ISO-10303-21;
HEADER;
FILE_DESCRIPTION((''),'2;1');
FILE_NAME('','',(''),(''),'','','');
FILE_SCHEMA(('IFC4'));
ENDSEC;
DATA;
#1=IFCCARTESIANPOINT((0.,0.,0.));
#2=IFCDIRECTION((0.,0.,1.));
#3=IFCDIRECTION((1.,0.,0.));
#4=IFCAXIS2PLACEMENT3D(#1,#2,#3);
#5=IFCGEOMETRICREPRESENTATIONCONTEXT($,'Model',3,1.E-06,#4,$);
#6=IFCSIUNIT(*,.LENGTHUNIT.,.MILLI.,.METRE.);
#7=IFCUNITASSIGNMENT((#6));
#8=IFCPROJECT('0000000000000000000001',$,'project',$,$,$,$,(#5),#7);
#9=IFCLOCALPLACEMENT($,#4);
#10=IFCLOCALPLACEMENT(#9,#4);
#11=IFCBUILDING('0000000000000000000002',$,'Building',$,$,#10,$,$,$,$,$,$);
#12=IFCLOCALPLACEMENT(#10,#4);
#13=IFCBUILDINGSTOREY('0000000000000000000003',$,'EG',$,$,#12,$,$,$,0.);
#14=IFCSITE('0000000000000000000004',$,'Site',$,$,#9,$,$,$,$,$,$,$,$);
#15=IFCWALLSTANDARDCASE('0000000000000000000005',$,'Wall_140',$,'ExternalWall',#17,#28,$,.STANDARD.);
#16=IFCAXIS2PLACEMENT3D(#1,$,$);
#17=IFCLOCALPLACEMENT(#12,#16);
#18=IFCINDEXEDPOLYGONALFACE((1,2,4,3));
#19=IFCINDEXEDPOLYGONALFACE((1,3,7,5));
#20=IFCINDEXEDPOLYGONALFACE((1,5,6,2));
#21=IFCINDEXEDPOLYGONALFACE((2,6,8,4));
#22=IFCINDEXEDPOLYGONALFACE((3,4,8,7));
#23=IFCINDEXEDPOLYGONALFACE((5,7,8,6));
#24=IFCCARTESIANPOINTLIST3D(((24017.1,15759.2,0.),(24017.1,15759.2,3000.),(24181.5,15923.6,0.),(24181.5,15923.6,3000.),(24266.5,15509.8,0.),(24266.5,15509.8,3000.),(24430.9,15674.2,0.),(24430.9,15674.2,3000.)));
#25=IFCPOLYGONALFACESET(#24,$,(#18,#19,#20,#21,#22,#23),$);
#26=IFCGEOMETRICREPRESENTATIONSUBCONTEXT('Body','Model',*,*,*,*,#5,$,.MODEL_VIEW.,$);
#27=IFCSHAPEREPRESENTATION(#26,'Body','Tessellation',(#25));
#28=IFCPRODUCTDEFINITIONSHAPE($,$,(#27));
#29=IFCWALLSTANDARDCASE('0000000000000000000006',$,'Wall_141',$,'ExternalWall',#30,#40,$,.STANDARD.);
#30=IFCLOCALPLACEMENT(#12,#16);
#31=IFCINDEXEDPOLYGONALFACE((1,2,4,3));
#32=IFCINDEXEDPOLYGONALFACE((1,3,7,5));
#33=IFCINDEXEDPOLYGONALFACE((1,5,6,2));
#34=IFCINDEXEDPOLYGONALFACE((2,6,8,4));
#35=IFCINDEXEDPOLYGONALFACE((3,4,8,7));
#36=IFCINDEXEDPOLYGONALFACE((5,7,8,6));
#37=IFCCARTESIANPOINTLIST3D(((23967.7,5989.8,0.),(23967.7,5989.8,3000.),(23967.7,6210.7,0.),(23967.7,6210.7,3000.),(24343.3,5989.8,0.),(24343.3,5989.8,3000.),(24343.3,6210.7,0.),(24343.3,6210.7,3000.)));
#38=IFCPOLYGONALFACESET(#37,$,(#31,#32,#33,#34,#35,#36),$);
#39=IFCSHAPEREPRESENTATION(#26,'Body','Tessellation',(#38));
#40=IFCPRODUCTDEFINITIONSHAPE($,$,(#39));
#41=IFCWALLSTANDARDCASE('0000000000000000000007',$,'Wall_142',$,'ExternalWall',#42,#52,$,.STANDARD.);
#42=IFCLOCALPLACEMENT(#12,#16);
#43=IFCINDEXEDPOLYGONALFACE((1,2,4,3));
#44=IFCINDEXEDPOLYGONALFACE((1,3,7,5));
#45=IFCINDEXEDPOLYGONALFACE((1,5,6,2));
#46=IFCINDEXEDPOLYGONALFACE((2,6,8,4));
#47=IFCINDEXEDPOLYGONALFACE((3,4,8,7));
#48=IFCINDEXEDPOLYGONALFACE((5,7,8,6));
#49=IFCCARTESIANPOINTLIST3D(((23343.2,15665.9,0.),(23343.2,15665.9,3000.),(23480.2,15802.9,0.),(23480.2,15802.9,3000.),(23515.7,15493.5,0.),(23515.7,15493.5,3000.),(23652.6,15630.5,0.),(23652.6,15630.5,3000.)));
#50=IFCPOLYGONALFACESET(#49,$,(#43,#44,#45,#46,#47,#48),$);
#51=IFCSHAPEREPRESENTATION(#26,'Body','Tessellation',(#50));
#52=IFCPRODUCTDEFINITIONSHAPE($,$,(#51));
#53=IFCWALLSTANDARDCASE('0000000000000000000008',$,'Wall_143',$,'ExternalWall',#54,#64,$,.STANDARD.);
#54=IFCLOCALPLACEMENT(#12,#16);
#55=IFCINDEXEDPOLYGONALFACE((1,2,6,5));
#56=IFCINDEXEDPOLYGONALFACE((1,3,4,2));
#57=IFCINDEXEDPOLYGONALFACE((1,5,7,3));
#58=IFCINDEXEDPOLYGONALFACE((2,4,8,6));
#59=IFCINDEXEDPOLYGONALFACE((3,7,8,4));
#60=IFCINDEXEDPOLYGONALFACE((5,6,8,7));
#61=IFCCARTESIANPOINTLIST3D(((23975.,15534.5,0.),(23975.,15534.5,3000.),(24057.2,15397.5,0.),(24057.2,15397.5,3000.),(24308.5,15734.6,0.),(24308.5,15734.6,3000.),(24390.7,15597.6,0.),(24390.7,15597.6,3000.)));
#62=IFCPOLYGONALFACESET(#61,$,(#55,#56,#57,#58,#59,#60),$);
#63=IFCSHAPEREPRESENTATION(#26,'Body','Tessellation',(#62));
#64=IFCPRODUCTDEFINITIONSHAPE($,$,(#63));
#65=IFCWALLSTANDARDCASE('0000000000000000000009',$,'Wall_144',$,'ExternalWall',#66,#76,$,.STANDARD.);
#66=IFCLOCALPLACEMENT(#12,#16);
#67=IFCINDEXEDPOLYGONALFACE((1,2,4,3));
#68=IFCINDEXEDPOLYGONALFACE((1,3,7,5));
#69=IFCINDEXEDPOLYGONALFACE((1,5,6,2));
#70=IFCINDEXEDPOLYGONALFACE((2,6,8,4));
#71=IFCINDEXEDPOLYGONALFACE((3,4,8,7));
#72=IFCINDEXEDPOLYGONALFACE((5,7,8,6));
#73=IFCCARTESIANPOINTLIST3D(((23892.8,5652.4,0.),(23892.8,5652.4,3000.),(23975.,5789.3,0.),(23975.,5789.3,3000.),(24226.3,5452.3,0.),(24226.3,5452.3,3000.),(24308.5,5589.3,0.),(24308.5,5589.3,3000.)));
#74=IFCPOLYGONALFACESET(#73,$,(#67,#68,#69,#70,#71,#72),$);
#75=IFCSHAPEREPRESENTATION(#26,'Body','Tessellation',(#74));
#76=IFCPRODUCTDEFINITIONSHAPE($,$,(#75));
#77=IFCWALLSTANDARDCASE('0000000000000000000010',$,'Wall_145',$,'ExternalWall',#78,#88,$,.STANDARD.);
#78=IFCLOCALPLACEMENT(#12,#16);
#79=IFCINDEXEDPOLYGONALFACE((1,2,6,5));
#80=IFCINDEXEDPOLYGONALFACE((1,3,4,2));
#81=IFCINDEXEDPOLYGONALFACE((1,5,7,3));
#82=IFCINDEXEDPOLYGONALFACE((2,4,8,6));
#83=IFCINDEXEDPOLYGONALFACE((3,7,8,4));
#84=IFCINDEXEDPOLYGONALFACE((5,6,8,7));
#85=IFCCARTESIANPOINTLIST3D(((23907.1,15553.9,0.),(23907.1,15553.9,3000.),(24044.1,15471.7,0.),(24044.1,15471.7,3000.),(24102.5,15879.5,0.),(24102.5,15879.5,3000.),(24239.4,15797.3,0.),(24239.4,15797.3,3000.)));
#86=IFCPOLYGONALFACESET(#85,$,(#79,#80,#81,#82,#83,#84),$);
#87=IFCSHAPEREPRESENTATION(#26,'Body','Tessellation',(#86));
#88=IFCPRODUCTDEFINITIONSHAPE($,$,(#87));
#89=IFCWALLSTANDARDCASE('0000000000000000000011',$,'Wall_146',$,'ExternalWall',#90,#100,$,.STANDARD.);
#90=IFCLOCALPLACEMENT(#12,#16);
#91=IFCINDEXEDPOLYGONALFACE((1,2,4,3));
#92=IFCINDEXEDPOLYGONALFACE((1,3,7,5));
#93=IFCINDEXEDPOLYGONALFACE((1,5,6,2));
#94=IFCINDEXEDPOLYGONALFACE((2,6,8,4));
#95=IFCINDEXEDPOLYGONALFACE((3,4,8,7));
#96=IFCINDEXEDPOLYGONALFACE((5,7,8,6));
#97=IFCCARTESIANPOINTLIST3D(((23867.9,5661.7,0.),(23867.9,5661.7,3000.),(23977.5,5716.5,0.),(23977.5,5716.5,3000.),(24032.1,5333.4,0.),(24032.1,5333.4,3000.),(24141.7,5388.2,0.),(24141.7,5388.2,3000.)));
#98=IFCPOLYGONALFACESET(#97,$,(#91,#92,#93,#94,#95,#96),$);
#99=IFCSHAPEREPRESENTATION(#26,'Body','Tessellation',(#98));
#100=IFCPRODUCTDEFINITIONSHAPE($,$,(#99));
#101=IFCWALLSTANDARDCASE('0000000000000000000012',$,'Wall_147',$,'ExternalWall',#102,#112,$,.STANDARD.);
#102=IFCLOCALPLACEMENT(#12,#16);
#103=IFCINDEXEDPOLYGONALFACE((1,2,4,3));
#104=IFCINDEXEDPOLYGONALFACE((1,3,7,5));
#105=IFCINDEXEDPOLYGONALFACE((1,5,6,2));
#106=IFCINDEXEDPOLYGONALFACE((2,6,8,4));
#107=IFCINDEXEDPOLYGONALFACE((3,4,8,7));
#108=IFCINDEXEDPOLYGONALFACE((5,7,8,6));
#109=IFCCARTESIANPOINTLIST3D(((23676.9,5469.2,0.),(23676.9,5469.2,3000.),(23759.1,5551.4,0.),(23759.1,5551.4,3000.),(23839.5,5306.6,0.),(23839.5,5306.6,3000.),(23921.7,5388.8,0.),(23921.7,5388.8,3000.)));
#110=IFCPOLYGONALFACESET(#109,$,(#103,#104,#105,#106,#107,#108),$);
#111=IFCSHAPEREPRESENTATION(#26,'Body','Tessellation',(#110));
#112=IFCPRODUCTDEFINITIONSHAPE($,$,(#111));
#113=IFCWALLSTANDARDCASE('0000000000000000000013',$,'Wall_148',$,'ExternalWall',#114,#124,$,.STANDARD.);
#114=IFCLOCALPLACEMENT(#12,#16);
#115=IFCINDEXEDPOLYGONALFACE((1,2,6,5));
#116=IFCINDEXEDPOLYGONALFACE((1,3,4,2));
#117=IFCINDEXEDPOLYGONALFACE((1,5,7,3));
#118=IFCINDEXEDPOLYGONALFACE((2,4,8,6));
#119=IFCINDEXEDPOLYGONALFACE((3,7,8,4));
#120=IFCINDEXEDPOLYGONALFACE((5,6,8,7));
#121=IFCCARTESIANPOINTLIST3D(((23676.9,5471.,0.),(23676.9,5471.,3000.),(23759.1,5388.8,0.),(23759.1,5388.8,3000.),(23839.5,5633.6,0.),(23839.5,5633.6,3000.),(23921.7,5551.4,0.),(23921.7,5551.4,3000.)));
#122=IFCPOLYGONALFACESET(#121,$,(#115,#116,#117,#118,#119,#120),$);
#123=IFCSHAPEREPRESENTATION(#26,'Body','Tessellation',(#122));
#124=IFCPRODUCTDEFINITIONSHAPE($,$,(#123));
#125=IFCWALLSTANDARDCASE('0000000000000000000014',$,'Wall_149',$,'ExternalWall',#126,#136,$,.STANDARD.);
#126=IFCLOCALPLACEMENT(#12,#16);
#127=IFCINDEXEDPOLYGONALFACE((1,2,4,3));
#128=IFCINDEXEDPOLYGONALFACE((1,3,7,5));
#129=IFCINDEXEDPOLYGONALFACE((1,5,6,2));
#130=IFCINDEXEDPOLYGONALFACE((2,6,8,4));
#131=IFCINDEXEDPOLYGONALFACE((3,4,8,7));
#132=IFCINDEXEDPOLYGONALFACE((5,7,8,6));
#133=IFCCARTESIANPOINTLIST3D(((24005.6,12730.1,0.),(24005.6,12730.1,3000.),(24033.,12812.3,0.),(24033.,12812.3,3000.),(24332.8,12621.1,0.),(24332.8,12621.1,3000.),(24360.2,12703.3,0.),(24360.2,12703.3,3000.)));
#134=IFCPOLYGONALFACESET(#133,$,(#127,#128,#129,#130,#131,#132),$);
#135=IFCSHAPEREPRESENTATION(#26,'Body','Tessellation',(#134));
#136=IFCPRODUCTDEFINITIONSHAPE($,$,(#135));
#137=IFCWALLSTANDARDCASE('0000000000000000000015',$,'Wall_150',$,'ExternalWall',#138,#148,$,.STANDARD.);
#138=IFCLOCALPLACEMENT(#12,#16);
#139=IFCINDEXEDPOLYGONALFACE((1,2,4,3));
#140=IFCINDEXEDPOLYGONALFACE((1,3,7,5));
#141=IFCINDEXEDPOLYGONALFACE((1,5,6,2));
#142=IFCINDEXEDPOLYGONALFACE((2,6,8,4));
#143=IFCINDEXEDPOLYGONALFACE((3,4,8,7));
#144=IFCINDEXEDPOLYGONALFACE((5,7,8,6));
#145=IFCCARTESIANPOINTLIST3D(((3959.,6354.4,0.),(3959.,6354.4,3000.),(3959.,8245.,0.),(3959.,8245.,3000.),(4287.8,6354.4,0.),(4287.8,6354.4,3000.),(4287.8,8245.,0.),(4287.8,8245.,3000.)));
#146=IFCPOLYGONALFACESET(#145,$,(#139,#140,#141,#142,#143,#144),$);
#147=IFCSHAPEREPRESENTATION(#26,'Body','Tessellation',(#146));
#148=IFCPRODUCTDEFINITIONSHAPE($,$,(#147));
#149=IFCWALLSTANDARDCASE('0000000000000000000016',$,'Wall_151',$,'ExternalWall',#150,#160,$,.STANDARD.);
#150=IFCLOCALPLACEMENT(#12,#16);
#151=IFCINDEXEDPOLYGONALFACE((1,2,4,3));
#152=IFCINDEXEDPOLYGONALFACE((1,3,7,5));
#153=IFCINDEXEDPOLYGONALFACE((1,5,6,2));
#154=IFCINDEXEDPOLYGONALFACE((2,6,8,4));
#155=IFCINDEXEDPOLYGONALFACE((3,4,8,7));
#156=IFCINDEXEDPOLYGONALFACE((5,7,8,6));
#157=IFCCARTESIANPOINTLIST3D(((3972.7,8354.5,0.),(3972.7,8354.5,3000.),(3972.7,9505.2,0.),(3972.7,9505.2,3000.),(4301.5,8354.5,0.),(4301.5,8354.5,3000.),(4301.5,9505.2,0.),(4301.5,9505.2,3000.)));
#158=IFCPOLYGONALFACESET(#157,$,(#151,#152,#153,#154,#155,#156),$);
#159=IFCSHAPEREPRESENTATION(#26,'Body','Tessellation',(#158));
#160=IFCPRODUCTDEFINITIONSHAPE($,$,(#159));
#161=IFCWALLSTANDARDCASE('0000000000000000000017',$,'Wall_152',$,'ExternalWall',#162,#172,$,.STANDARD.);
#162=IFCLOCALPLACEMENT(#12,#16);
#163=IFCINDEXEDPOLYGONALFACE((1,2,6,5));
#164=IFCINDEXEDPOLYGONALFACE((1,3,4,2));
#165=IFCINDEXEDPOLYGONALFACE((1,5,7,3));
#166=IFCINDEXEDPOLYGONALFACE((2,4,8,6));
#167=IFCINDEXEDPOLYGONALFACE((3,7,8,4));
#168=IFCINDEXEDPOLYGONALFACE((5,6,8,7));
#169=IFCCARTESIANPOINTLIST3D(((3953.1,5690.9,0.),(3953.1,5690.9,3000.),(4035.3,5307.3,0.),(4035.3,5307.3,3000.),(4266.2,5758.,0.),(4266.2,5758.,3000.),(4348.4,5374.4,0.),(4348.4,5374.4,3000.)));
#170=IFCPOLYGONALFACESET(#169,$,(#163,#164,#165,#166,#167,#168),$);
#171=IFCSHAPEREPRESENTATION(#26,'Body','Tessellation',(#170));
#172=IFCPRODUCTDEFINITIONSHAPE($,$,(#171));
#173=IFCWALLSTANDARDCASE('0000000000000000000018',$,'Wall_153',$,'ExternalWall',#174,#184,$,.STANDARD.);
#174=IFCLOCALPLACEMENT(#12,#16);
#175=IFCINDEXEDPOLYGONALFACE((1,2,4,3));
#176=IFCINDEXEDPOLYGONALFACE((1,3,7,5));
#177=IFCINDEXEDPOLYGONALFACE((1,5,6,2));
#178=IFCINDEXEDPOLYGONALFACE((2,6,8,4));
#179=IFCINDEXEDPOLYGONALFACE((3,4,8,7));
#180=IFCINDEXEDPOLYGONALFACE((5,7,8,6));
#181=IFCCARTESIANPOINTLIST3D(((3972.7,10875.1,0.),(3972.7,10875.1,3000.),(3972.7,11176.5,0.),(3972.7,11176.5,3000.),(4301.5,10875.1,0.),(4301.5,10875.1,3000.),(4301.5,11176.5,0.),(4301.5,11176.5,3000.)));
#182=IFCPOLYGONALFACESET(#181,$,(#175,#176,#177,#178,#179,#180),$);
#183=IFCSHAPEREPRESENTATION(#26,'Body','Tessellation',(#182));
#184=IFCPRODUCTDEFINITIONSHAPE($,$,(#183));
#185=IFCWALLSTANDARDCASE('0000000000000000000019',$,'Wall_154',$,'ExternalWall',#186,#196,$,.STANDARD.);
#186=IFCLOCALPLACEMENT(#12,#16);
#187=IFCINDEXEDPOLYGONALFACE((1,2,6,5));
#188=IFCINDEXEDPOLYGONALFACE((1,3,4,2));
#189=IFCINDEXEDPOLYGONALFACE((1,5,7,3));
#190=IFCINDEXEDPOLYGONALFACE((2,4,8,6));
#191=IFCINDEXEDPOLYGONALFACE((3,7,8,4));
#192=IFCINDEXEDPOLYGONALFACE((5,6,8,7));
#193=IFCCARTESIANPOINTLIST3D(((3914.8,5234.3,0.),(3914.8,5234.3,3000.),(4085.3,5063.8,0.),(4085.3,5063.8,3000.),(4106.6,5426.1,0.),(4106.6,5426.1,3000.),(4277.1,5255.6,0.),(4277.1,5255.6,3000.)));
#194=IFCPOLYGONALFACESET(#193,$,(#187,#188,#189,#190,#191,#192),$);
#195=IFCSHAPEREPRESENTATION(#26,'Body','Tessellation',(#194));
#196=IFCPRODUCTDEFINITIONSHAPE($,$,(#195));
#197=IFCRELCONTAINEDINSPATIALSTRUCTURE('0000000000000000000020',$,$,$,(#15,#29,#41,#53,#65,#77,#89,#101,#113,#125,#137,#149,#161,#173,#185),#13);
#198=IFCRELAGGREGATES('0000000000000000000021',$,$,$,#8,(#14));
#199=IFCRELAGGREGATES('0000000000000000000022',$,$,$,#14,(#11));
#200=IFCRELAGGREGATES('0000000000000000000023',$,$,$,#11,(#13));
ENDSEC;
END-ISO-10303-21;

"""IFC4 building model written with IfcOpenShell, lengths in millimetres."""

from ifc_helpers import new_model, si_unit, frame, origin_with_axes, place, context, subcontext, project, spatial, rectangle, extrude, element, save


model = new_model("IFC4")

# Units and contexts
model_context = context("Model", 3, precision=1e-06, world=origin_with_axes())
body_context = subcontext(model_context, "Body", "Model", "MODEL_VIEW")
ifc_project = project(units=[si_unit("LENGTHUNIT", "METRE", prefix="MILLI")], contexts=[model_context])

# Site, building, storey
site_placement = place(None, origin_with_axes())
site = spatial("IfcSite", under=ifc_project, at=site_placement, Name="Site")
building_placement = place(site_placement, origin_with_axes())
building = spatial("IfcBuilding", under=site, at=building_placement, Name="Building")
storey_placement = place(building_placement, origin_with_axes())
storey = spatial("IfcBuildingStorey", under=building, at=storey_placement, Name="EG", Elevation=0.0)

# Walls
wall_1_placement = place(storey_placement, origin_with_axes())
element("IfcWallStandardCase", 1, at=wall_1_placement, inside=storey, Name="Wall_140", ObjectType="ExternalWall", PredefinedType="STANDARD", context=body_context, shape_type="SweptSolid", body=[
    extrude(rectangle(XDim=232.5, YDim=352.7), frame((24224.0, 15716.7, 0.0), z_axis=(0.0, 0.0, 1.0), x_axis=(0.707107, 0.707107, 0.0)), (0.0, 0.0, 1.0), 3000.0),
])
wall_2_placement = place(storey_placement, origin_with_axes())
element("IfcWallStandardCase", 2, at=wall_2_placement, inside=storey, Name="Wall_141", ObjectType="ExternalWall", PredefinedType="STANDARD", context=body_context, shape_type="SweptSolid", body=[
    extrude(rectangle(XDim=220.9, YDim=375.6), frame((24155.5, 6100.3, 0.0), z_axis=(0.0, 0.0, 1.0), x_axis=(0.0, -1.0, 0.0)), (0.0, 0.0, 1.0), 3000.0),
])
wall_3_placement = place(storey_placement, origin_with_axes())
element("IfcWallStandardCase", 3, at=wall_3_placement, inside=storey, Name="Wall_142", ObjectType="ExternalWall", PredefinedType="STANDARD", context=body_context, shape_type="SweptSolid", body=[
    extrude(rectangle(XDim=193.7, YDim=243.8), frame((23497.9, 15648.2, 0.0), z_axis=(0.0, 0.0, 1.0), x_axis=(-0.707107, -0.707107, 0.0)), (0.0, 0.0, 1.0), 3000.0),
])
wall_4_placement = place(storey_placement, origin_with_axes())
element("IfcWallStandardCase", 4, at=wall_4_placement, inside=storey, Name="Wall_143", ObjectType="ExternalWall", PredefinedType="STANDARD", context=body_context, shape_type="SweptSolid", body=[
    extrude(rectangle(XDim=159.8, YDim=388.9), frame((24182.9, 15566.0, 0.0), z_axis=(0.0, 0.0, 1.0), x_axis=(-0.514496, 0.857493, 0.0)), (0.0, 0.0, 1.0), 3000.0),
])
wall_5_placement = place(storey_placement, origin_with_axes())
element("IfcWallStandardCase", 5, at=wall_5_placement, inside=storey, Name="Wall_144", ObjectType="ExternalWall", PredefinedType="STANDARD", context=body_context, shape_type="SweptSolid", body=[
    extrude(rectangle(XDim=159.8, YDim=388.9), frame((24100.7, 5620.8, 0.0), z_axis=(0.0, 0.0, 1.0), x_axis=(-0.514496, -0.857493, 0.0)), (0.0, 0.0, 1.0), 3000.0),
])
wall_6_placement = place(storey_placement, origin_with_axes())
element("IfcWallStandardCase", 6, at=wall_6_placement, inside=storey, Name="Wall_145", ObjectType="ExternalWall", PredefinedType="STANDARD", context=body_context, shape_type="SweptSolid", body=[
    extrude(rectangle(XDim=159.8, YDim=379.6), frame((24073.3, 15675.6, 0.0), z_axis=(0.0, 0.0, 1.0), x_axis=(-0.857493, 0.514496, 0.0)), (0.0, 0.0, 1.0), 3000.0),
])
wall_7_placement = place(storey_placement, origin_with_axes())
element("IfcWallStandardCase", 7, at=wall_7_placement, inside=storey, Name="Wall_146", ObjectType="ExternalWall", PredefinedType="STANDARD", context=body_context, shape_type="SweptSolid", body=[
    extrude(rectangle(XDim=122.5, YDim=367.0), frame((24004.8, 5524.9, 0.0), z_axis=(0.0, 0.0, 1.0), x_axis=(-0.894427, -0.447214, 0.0)), (0.0, 0.0, 1.0), 3000.0),
])
wall_8_placement = place(storey_placement, origin_with_axes())
element("IfcWallStandardCase", 8, at=wall_8_placement, inside=storey, Name="Wall_147", ObjectType="ExternalWall", PredefinedType="STANDARD", context=body_context, shape_type="SweptSolid", body=[
    extrude(rectangle(XDim=116.2, YDim=230.0), frame((23799.3, 5429.0, 0.0), z_axis=(0.0, 0.0, 1.0), x_axis=(-0.707107, -0.707107, 0.0)), (0.0, 0.0, 1.0), 3000.0),
])
wall_9_placement = place(storey_placement, origin_with_axes())
element("IfcWallStandardCase", 9, at=wall_9_placement, inside=storey, Name="Wall_148", ObjectType="ExternalWall", PredefinedType="STANDARD", context=body_context, shape_type="SweptSolid", body=[
    extrude(rectangle(XDim=116.2, YDim=230.0), frame((23799.3, 5511.2, 0.0), z_axis=(0.0, 0.0, 1.0), x_axis=(-0.707107, 0.707107, 0.0)), (0.0, 0.0, 1.0), 3000.0),
])
wall_10_placement = place(storey_placement, origin_with_axes())
element("IfcWallStandardCase", 10, at=wall_10_placement, inside=storey, Name="Wall_149", ObjectType="ExternalWall", PredefinedType="STANDARD", context=body_context, shape_type="SweptSolid", body=[
    extrude(rectangle(XDim=86.6, YDim=345.0), frame((24182.9, 12716.7, 0.0), z_axis=(0.0, 0.0, 1.0), x_axis=(0.316228, 0.948683, 0.0)), (0.0, 0.0, 1.0), 3000.0),
])
wall_11_placement = place(storey_placement, origin_with_axes())
element("IfcWallStandardCase", 11, at=wall_11_placement, inside=storey, Name="Wall_150", ObjectType="ExternalWall", PredefinedType="STANDARD", context=body_context, shape_type="SweptSolid", body=[
    extrude(rectangle(XDim=1890.6, YDim=328.8), frame((4123.4, 7299.7, 0.0), z_axis=(0.0, 0.0, 1.0), x_axis=(0.0, 1.0, 0.0)), (0.0, 0.0, 1.0), 3000.0),
])
wall_12_placement = place(storey_placement, origin_with_axes())
element("IfcWallStandardCase", 12, at=wall_12_placement, inside=storey, Name="Wall_151", ObjectType="ExternalWall", PredefinedType="STANDARD", context=body_context, shape_type="SweptSolid", body=[
    extrude(rectangle(XDim=1150.7, YDim=328.8), frame((4137.1, 8929.9, 0.0), z_axis=(0.0, 0.0, 1.0), x_axis=(0.0, 1.0, 0.0)), (0.0, 0.0, 1.0), 3000.0),
])
wall_13_placement = place(storey_placement, origin_with_axes())
element("IfcWallStandardCase", 13, at=wall_13_placement, inside=storey, Name="Wall_152", ObjectType="ExternalWall", PredefinedType="STANDARD", context=body_context, shape_type="SweptSolid", body=[
    extrude(rectangle(XDim=392.3, YDim=320.2), frame((4150.8, 5532.6, 0.0), z_axis=(0.0, 0.0, 1.0), x_axis=(-0.209529, 0.977802, 0.0)), (0.0, 0.0, 1.0), 3000.0),
])
wall_14_placement = place(storey_placement, origin_with_axes())
element("IfcWallStandardCase", 14, at=wall_14_placement, inside=storey, Name="Wall_153", ObjectType="ExternalWall", PredefinedType="STANDARD", context=body_context, shape_type="SweptSolid", body=[
    extrude(rectangle(XDim=301.4, YDim=328.8), frame((4137.1, 11025.8, 0.0), z_axis=(0.0, 0.0, 1.0), x_axis=(0.0, 1.0, 0.0)), (0.0, 0.0, 1.0), 3000.0),
])
wall_15_placement = place(storey_placement, origin_with_axes())
element("IfcWallStandardCase", 15, at=wall_15_placement, inside=storey, Name="Wall_154", ObjectType="ExternalWall", PredefinedType="STANDARD", context=body_context, shape_type="SweptSolid", body=[
    extrude(rectangle(XDim=271.2, YDim=241.1), frame((4096.0, 5244.9, 0.0), z_axis=(0.0, 0.0, 1.0), x_axis=(-0.707107, -0.707107, 0.0)), (0.0, 0.0, 1.0), 3000.0),
])

save(model, "model.ifc")
